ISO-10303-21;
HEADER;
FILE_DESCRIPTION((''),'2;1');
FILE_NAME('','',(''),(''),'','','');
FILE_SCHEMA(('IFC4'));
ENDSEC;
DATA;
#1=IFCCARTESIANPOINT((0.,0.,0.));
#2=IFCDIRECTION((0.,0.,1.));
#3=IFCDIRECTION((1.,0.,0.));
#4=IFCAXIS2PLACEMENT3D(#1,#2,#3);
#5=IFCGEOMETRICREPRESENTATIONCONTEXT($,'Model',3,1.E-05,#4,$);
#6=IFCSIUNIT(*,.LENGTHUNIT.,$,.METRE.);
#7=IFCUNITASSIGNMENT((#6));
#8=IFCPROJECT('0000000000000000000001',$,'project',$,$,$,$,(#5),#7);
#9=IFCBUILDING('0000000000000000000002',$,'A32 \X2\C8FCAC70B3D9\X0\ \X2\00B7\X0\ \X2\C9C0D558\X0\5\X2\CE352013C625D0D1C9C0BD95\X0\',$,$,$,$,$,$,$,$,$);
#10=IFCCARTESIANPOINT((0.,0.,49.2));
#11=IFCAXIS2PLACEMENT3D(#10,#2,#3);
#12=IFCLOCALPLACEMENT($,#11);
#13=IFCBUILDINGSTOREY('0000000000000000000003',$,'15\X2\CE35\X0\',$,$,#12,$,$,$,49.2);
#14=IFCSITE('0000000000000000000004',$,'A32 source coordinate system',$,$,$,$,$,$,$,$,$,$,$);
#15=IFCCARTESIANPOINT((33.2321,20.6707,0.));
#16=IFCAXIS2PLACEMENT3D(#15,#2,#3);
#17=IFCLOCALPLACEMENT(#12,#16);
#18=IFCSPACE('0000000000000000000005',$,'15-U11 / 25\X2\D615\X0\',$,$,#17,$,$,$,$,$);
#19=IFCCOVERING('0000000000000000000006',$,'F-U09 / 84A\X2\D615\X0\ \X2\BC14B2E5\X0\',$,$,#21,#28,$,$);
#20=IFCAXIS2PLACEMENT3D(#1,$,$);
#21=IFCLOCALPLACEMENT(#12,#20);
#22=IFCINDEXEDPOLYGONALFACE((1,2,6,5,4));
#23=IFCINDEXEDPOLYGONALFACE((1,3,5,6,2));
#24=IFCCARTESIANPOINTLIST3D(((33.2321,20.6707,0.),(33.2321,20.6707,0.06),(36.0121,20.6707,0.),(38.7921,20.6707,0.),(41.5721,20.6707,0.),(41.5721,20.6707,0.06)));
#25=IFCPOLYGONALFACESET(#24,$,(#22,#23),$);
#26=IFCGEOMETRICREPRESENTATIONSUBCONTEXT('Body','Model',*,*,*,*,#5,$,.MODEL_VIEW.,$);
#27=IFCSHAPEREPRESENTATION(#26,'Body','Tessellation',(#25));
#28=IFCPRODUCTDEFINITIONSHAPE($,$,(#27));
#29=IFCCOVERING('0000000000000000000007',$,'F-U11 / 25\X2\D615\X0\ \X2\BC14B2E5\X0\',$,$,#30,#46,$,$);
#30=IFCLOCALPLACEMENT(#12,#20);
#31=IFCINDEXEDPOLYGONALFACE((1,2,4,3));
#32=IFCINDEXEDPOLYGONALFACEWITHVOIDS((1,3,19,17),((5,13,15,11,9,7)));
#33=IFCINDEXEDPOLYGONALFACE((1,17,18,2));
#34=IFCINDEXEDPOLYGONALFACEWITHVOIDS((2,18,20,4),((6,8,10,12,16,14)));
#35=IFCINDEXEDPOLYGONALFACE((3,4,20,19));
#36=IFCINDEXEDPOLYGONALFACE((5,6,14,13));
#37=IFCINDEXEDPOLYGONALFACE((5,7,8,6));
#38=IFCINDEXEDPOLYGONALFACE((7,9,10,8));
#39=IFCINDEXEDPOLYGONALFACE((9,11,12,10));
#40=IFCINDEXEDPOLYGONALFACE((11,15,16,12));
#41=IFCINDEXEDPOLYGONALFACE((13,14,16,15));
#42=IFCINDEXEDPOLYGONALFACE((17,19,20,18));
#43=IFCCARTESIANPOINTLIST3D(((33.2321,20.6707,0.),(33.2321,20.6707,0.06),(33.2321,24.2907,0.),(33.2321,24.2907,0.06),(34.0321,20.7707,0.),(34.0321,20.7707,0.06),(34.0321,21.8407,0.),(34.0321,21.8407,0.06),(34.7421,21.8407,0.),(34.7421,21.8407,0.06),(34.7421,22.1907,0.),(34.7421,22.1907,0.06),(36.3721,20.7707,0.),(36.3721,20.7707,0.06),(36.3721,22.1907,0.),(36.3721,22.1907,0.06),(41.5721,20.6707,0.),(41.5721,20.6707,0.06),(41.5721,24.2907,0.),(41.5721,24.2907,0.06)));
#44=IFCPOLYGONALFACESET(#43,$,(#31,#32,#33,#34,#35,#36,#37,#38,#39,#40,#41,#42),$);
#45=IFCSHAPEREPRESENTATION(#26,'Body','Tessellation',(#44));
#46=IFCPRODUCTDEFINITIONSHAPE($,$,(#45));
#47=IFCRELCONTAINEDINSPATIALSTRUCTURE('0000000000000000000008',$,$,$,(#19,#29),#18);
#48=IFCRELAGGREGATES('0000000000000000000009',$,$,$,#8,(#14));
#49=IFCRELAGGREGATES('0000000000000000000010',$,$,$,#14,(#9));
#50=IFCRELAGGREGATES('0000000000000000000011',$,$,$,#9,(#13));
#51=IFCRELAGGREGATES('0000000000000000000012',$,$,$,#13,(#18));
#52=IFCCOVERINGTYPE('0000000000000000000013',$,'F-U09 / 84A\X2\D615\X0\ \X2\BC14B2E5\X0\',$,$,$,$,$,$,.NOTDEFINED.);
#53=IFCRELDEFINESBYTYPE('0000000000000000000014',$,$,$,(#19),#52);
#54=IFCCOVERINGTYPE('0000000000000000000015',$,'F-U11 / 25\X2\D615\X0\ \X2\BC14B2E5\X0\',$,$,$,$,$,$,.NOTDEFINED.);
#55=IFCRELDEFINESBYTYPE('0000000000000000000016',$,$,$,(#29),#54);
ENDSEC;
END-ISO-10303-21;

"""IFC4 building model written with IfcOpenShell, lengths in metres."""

from ifc_helpers import new_model, si_unit, frame, origin, origin_with_axes, place, context, subcontext, project, spatial, polyline, outline, extrude, source, transform, mapped, type_object, type_shapes, element, save


model = new_model("IFC4")

# Units and contexts
model_context = context("Model", 3, precision=1e-05, world=origin_with_axes())
body_context = subcontext(model_context, "Body", "Model", "MODEL_VIEW")
ifc_project = project(units=[si_unit("LENGTHUNIT", "METRE")], contexts=[model_context])

# Site, building, storey
site = spatial("IfcSite", under=ifc_project, Name="A32 source coordinate system")
building = spatial("IfcBuilding", under=site, Name="A32 주거동 · 지하5층–옥탑지붕")
storey_placement = place(None, frame((0.0, 0.0, 49.2), z_axis=(0.0, 0.0, 1.0), x_axis=(1.0, 0.0, 0.0)))
storey = spatial("IfcBuildingStorey", under=building, at=storey_placement, Name="15층", Elevation=49.2)

# Shared definitions
space_1_placement = place(storey_placement, frame((33.2321, 20.6707, 0.0), z_axis=(0.0, 0.0, 1.0), x_axis=(1.0, 0.0, 0.0)))
space_1 = spatial("IfcSpace", under=storey, at=space_1_placement, Name="15-U11 / 25형")

# Coverings
covering_type_1 = type_object("IfcCoveringType", Name="F-U09 / 84A형 바닥", PredefinedType="NOTDEFINED")
shared_shape_1 = source(origin(), body_context, "Body", "SweptSolid", [
    extrude(outline(polyline([(0.0, 0.0), (8.34, 0.0), (8.34, 0.0), (0.0, 0.0), (0.0, 0.0)])), origin(), (0.0, 0.0, 1.0), 0.06),
])
type_shapes(covering_type_1, [shared_shape_1])
covering_1_placement = place(space_1_placement, origin_with_axes())
element("IfcCovering", 1, at=covering_1_placement, inside=space_1, type_object=covering_type_1, Name="F-U09 / 84A형 바닥", context=body_context, shape_type="MappedRepresentation", body=[
    mapped(shared_shape_1, transform((0.0, 0.0, 0.0), scale=1.0)),
])
covering_type_2 = type_object("IfcCoveringType", Name="F-U11 / 25형 바닥", PredefinedType="NOTDEFINED")
shared_shape_2 = source(origin(), body_context, "Body", "SweptSolid", [
    extrude(outline(polyline([(0.0, 0.0), (0.0, 3.62), (8.34, 3.62), (8.34, 0.0), (0.0, 0.0)]), holes=[polyline([(1.51, 1.17), (0.8, 1.17), (0.8, 0.1), (3.14, 0.1), (3.14, 1.52), (1.51, 1.52), (1.51, 1.17)])]), origin(), (0.0, 0.0, 1.0), 0.06),
])
type_shapes(covering_type_2, [shared_shape_2])
covering_2_placement = place(space_1_placement, origin_with_axes())
element("IfcCovering", 2, at=covering_2_placement, inside=space_1, type_object=covering_type_2, Name="F-U11 / 25형 바닥", context=body_context, shape_type="MappedRepresentation", body=[
    mapped(shared_shape_2, transform((0.0, 0.0, 0.0), scale=1.0)),
])

save(model, "model.ifc")
